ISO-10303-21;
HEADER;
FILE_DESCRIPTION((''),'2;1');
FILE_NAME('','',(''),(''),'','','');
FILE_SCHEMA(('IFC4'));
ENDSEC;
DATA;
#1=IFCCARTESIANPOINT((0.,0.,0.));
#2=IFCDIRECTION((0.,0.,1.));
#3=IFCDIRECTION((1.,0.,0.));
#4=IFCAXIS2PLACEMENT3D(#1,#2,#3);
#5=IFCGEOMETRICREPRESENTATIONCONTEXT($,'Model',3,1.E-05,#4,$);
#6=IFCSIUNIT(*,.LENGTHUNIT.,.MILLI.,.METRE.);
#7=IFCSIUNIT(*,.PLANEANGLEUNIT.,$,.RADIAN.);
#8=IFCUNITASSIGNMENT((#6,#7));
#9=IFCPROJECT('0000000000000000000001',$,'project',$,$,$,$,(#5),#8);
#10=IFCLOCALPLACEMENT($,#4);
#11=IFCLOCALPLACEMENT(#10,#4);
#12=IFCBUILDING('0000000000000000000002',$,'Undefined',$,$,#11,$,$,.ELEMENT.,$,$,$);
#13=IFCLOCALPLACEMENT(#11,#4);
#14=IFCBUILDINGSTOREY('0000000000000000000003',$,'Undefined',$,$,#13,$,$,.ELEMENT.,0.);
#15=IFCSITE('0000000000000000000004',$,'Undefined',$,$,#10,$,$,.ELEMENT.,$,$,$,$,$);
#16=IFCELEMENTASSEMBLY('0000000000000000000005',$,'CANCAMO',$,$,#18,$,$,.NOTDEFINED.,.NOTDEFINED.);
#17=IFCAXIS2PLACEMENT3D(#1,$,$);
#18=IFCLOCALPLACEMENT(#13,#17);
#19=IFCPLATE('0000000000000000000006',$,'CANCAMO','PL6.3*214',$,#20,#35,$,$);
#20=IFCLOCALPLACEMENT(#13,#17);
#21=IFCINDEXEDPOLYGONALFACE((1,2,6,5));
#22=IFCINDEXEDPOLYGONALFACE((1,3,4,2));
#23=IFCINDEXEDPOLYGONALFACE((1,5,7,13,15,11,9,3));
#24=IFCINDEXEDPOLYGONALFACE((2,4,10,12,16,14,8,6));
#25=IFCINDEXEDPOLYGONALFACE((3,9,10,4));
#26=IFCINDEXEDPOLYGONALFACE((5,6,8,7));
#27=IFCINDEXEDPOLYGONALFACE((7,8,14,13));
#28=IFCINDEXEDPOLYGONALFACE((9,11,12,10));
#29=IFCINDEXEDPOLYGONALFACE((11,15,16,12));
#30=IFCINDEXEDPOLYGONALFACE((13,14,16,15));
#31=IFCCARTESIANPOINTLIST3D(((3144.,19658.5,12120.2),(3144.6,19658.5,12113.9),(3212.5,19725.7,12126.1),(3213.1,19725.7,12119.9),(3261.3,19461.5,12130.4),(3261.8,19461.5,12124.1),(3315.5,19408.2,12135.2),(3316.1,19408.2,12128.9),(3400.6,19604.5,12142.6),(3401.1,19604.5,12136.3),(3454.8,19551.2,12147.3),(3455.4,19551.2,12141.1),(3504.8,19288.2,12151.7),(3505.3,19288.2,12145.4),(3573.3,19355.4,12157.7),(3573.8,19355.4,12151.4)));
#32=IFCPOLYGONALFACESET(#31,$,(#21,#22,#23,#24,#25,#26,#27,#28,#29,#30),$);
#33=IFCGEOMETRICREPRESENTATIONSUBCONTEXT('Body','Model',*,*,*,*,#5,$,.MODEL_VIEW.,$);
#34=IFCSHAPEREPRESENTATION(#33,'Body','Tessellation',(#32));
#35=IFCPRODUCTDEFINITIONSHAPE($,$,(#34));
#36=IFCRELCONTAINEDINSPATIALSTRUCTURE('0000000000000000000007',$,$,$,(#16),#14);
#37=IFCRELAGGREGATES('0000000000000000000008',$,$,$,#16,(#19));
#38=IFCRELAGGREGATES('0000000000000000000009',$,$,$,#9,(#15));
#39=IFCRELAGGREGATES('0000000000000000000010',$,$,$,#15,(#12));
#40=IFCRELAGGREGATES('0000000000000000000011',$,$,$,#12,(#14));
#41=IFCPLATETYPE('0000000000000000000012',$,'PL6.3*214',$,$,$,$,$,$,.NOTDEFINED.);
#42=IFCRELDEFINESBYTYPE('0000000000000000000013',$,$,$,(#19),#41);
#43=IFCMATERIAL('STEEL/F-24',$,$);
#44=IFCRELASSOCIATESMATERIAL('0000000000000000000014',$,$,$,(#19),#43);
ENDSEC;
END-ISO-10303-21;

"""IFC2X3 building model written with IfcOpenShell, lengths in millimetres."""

from ifc_helpers import new_model, si_unit, frame, origin_with_axes, place, context, subcontext, project, spatial, polyline, outline, extrude, material, type_object, element, aggregate, save


model = new_model("IFC2X3")

# Units and contexts
model_context = context("Model", 3, precision=1e-05, world=origin_with_axes())
body_context = subcontext(model_context, "Body", "Model", "MODEL_VIEW")
ifc_project = project(units=[si_unit("LENGTHUNIT", "METRE", prefix="MILLI"), si_unit("PLANEANGLEUNIT", "RADIAN")], contexts=[model_context])

# Site, building, storey
site_placement = place(None, origin_with_axes())
site = spatial("IfcSite", under=ifc_project, at=site_placement, Name="Undefined", CompositionType="ELEMENT")
building_placement = place(site_placement, origin_with_axes())
building = spatial("IfcBuilding", under=site, at=building_placement, Name="Undefined", CompositionType="ELEMENT")
storey_placement = place(building_placement, origin_with_axes())
storey = spatial("IfcBuildingStorey", under=building, at=storey_placement, Name="Undefined", CompositionType="ELEMENT", Elevation=0.0)

# Shared definitions
ifc_material_1 = material(Name="STEEL/F-24")

# Element assembly, plate
assembly_1_placement = place(storey_placement, origin_with_axes())
assembly_1 = element("IfcElementAssembly", 1, at=assembly_1_placement, inside=storey, Name="CANCAMO", AssemblyPlace="NOTDEFINED", PredefinedType="NOTDEFINED")
plate_type_1 = type_object("IfcPlateType", Name="PL6.3*214", PredefinedType="NOTDEFINED")
plate_1_placement = place(assembly_1_placement, frame((3505.0, 19288.2, 12148.6), z_axis=(-0.087156, 0.0, 0.996195), x_axis=(0.712265, 0.699139, 0.062315)))
plate_1 = element("IfcPlate", 2, at=plate_1_placement, type_object=plate_type_1, material=ifc_material_1, Name="CANCAMO", Description="PL6.3*214", context=body_context, shape_type="SweptSolid", body=[
    extrude(outline(polyline([(0.0, 0.0), (96.2, 0.0), (148.1, 223.1), (146.4, 299.3), (96.2, 517.9), (0.0, 517.9), (-53.6, 294.8), (-51.9, 218.6), (0.0, 0.0)])), frame((0.0, 0.0, -3.1), z_axis=(0.0, 0.0, 1.0), x_axis=(1.0, 0.0, 0.0)), (0.0, 0.0, 1.0), 6.3),
])
aggregate(assembly_1, [plate_1])

save(model, "model.ifc")
